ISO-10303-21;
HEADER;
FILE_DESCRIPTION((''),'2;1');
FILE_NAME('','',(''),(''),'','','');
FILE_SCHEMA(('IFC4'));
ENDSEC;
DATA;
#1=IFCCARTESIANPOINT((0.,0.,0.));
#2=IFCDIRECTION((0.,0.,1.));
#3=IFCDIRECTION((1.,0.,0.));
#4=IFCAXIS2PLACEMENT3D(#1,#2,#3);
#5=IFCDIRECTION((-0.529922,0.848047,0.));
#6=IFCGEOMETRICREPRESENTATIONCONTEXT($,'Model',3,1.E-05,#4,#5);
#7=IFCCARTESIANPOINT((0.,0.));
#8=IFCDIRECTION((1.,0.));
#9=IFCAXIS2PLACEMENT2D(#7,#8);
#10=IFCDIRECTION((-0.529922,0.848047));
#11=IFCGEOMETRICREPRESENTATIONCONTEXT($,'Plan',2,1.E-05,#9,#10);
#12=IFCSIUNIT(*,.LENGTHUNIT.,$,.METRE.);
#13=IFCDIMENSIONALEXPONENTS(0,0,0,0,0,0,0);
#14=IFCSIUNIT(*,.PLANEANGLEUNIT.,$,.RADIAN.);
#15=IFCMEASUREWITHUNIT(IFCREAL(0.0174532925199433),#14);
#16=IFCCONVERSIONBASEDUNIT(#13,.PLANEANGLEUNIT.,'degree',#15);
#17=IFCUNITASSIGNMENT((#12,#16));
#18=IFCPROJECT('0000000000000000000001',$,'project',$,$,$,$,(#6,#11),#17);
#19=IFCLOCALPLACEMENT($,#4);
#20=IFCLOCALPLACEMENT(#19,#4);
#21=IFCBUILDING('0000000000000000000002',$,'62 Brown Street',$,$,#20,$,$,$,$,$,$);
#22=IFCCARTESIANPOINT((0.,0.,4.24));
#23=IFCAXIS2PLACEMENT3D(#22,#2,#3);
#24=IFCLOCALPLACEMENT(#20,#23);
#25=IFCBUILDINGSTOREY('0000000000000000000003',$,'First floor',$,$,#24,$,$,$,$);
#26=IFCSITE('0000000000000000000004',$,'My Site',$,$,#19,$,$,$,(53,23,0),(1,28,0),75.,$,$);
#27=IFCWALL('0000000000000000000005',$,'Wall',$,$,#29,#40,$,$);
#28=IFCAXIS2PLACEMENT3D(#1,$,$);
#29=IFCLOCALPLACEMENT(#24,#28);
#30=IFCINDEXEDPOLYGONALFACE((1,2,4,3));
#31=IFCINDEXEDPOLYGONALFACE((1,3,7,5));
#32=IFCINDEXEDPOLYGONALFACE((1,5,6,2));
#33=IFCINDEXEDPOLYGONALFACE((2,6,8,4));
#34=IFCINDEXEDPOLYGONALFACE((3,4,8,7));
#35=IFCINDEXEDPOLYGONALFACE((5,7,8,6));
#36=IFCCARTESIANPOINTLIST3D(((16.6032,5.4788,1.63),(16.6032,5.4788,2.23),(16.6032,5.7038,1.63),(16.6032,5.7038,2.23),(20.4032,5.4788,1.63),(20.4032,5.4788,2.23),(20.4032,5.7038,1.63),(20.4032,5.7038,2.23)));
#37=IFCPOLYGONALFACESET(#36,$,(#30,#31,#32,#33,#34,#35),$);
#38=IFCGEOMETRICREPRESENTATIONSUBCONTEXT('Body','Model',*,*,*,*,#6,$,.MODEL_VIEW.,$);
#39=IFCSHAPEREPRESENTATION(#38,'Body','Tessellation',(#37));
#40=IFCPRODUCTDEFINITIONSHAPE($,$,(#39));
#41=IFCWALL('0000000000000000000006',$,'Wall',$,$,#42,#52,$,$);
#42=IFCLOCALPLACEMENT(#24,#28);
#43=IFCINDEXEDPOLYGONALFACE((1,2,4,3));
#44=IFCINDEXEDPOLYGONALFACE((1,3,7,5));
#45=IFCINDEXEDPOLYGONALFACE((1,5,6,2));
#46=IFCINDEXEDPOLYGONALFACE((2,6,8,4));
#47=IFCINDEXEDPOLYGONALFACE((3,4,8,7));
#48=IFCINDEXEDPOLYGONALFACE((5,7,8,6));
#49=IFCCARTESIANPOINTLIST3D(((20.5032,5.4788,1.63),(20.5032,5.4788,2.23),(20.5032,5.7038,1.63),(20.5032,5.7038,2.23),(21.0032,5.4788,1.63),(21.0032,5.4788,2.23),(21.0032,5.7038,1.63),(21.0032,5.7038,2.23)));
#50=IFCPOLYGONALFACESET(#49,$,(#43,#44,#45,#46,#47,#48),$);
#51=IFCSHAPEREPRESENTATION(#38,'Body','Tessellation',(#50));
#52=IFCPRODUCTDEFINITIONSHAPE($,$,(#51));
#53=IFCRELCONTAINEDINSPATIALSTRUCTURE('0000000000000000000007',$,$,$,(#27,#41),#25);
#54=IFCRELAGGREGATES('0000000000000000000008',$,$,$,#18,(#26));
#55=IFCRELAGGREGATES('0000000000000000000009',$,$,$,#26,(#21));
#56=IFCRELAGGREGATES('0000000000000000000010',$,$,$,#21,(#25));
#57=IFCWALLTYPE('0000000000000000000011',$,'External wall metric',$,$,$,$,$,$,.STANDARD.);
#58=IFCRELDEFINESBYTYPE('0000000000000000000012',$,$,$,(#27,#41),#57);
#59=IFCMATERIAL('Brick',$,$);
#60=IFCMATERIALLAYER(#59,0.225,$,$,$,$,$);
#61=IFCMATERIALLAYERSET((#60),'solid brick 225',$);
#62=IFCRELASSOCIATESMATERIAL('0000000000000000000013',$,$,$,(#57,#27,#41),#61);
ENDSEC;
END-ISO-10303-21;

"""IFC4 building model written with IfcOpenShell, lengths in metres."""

from ifc_helpers import new_model, entity, si_unit, converted_unit, direction, frame, origin_with_axes, origin_2d_with_axis, place, context, subcontext, project, spatial, indexed_curve, outline, extrude, material, layer, layer_set, layer_usage, type_object, element, save


model = new_model("IFC4")

# Units and contexts
model_context = context("Model", 3, precision=1e-05, world=origin_with_axes(), true_north=direction((-0.529922, 0.848047, 0.0)))
plan_context = context("Plan", 2, precision=1e-05, world=origin_2d_with_axis(), true_north=direction((-0.529922, 0.848047)))
body_context = subcontext(model_context, "Body", "Model", "MODEL_VIEW")
ifc_project = project(units=[si_unit("LENGTHUNIT", "METRE"), converted_unit("PLANEANGLEUNIT", "degree", entity("IfcReal", 0.0174532925199433), si_unit("PLANEANGLEUNIT", "RADIAN"), dimensions=[0, 0, 0, 0, 0, 0, 0])], contexts=[model_context, plan_context])

# Site, building, storey
site_placement = place(None, origin_with_axes())
site = spatial("IfcSite", under=ifc_project, at=site_placement, Name="My Site", RefLatitude=(53, 23, 0), RefLongitude=(1, 28, 0), RefElevation=75.0)
building_placement = place(site_placement, origin_with_axes())
building = spatial("IfcBuilding", under=site, at=building_placement, Name="62 Brown Street")
storey_placement = place(building_placement, frame((0.0, 0.0, 4.24), z_axis=(0.0, 0.0, 1.0), x_axis=(1.0, 0.0, 0.0)))
storey = spatial("IfcBuildingStorey", under=building, at=storey_placement, Name="First floor")

# Walls
ifc_material_1 = material(Name="Brick")
ifc_layer_1 = layer(ifc_material_1, 0.225)
ifc_layer_set_1 = layer_set([ifc_layer_1], Name="solid brick 225")
wall_type_1 = type_object("IfcWallType", Name="External wall metric", PredefinedType="STANDARD", material=ifc_layer_set_1)
ifc_layer_usage_1 = layer_usage(ifc_layer_set_1, "AXIS2", "POSITIVE", 0.0)
wall_1_placement = place(storey_placement, frame((16.6032, 5.4788, 1.63), z_axis=(0.0, 0.0, 1.0), x_axis=(1.0, 0.0, 0.0)))
element("IfcWall", 1, at=wall_1_placement, inside=storey, type_object=wall_type_1, material=ifc_layer_usage_1, Name="Wall", context=body_context, shape_type="SweptSolid", body=[
    extrude(outline(indexed_curve([(0.0, 0.0), (0.0, 0.225), (3.8, 0.225), (3.8, 0.0), (0.0, 0.0)], self_intersect=False)), origin_with_axes(), (0.0, 0.0, 1.0), 0.6),
])
ifc_layer_usage_2 = layer_usage(ifc_layer_set_1, "AXIS2", "POSITIVE", 0.0)
wall_2_placement = place(storey_placement, frame((20.5032, 5.4788, 1.63), z_axis=(0.0, 0.0, 1.0), x_axis=(1.0, 0.0, 0.0)))
element("IfcWall", 2, at=wall_2_placement, inside=storey, type_object=wall_type_1, material=ifc_layer_usage_2, Name="Wall", context=body_context, shape_type="SweptSolid", body=[
    extrude(outline(indexed_curve([(0.0, 0.0), (0.0, 0.225), (0.5, 0.225), (0.5, 0.0), (0.0, 0.0)], self_intersect=False)), origin_with_axes(), (0.0, 0.0, 1.0), 0.6),
])

save(model, "model.ifc")
